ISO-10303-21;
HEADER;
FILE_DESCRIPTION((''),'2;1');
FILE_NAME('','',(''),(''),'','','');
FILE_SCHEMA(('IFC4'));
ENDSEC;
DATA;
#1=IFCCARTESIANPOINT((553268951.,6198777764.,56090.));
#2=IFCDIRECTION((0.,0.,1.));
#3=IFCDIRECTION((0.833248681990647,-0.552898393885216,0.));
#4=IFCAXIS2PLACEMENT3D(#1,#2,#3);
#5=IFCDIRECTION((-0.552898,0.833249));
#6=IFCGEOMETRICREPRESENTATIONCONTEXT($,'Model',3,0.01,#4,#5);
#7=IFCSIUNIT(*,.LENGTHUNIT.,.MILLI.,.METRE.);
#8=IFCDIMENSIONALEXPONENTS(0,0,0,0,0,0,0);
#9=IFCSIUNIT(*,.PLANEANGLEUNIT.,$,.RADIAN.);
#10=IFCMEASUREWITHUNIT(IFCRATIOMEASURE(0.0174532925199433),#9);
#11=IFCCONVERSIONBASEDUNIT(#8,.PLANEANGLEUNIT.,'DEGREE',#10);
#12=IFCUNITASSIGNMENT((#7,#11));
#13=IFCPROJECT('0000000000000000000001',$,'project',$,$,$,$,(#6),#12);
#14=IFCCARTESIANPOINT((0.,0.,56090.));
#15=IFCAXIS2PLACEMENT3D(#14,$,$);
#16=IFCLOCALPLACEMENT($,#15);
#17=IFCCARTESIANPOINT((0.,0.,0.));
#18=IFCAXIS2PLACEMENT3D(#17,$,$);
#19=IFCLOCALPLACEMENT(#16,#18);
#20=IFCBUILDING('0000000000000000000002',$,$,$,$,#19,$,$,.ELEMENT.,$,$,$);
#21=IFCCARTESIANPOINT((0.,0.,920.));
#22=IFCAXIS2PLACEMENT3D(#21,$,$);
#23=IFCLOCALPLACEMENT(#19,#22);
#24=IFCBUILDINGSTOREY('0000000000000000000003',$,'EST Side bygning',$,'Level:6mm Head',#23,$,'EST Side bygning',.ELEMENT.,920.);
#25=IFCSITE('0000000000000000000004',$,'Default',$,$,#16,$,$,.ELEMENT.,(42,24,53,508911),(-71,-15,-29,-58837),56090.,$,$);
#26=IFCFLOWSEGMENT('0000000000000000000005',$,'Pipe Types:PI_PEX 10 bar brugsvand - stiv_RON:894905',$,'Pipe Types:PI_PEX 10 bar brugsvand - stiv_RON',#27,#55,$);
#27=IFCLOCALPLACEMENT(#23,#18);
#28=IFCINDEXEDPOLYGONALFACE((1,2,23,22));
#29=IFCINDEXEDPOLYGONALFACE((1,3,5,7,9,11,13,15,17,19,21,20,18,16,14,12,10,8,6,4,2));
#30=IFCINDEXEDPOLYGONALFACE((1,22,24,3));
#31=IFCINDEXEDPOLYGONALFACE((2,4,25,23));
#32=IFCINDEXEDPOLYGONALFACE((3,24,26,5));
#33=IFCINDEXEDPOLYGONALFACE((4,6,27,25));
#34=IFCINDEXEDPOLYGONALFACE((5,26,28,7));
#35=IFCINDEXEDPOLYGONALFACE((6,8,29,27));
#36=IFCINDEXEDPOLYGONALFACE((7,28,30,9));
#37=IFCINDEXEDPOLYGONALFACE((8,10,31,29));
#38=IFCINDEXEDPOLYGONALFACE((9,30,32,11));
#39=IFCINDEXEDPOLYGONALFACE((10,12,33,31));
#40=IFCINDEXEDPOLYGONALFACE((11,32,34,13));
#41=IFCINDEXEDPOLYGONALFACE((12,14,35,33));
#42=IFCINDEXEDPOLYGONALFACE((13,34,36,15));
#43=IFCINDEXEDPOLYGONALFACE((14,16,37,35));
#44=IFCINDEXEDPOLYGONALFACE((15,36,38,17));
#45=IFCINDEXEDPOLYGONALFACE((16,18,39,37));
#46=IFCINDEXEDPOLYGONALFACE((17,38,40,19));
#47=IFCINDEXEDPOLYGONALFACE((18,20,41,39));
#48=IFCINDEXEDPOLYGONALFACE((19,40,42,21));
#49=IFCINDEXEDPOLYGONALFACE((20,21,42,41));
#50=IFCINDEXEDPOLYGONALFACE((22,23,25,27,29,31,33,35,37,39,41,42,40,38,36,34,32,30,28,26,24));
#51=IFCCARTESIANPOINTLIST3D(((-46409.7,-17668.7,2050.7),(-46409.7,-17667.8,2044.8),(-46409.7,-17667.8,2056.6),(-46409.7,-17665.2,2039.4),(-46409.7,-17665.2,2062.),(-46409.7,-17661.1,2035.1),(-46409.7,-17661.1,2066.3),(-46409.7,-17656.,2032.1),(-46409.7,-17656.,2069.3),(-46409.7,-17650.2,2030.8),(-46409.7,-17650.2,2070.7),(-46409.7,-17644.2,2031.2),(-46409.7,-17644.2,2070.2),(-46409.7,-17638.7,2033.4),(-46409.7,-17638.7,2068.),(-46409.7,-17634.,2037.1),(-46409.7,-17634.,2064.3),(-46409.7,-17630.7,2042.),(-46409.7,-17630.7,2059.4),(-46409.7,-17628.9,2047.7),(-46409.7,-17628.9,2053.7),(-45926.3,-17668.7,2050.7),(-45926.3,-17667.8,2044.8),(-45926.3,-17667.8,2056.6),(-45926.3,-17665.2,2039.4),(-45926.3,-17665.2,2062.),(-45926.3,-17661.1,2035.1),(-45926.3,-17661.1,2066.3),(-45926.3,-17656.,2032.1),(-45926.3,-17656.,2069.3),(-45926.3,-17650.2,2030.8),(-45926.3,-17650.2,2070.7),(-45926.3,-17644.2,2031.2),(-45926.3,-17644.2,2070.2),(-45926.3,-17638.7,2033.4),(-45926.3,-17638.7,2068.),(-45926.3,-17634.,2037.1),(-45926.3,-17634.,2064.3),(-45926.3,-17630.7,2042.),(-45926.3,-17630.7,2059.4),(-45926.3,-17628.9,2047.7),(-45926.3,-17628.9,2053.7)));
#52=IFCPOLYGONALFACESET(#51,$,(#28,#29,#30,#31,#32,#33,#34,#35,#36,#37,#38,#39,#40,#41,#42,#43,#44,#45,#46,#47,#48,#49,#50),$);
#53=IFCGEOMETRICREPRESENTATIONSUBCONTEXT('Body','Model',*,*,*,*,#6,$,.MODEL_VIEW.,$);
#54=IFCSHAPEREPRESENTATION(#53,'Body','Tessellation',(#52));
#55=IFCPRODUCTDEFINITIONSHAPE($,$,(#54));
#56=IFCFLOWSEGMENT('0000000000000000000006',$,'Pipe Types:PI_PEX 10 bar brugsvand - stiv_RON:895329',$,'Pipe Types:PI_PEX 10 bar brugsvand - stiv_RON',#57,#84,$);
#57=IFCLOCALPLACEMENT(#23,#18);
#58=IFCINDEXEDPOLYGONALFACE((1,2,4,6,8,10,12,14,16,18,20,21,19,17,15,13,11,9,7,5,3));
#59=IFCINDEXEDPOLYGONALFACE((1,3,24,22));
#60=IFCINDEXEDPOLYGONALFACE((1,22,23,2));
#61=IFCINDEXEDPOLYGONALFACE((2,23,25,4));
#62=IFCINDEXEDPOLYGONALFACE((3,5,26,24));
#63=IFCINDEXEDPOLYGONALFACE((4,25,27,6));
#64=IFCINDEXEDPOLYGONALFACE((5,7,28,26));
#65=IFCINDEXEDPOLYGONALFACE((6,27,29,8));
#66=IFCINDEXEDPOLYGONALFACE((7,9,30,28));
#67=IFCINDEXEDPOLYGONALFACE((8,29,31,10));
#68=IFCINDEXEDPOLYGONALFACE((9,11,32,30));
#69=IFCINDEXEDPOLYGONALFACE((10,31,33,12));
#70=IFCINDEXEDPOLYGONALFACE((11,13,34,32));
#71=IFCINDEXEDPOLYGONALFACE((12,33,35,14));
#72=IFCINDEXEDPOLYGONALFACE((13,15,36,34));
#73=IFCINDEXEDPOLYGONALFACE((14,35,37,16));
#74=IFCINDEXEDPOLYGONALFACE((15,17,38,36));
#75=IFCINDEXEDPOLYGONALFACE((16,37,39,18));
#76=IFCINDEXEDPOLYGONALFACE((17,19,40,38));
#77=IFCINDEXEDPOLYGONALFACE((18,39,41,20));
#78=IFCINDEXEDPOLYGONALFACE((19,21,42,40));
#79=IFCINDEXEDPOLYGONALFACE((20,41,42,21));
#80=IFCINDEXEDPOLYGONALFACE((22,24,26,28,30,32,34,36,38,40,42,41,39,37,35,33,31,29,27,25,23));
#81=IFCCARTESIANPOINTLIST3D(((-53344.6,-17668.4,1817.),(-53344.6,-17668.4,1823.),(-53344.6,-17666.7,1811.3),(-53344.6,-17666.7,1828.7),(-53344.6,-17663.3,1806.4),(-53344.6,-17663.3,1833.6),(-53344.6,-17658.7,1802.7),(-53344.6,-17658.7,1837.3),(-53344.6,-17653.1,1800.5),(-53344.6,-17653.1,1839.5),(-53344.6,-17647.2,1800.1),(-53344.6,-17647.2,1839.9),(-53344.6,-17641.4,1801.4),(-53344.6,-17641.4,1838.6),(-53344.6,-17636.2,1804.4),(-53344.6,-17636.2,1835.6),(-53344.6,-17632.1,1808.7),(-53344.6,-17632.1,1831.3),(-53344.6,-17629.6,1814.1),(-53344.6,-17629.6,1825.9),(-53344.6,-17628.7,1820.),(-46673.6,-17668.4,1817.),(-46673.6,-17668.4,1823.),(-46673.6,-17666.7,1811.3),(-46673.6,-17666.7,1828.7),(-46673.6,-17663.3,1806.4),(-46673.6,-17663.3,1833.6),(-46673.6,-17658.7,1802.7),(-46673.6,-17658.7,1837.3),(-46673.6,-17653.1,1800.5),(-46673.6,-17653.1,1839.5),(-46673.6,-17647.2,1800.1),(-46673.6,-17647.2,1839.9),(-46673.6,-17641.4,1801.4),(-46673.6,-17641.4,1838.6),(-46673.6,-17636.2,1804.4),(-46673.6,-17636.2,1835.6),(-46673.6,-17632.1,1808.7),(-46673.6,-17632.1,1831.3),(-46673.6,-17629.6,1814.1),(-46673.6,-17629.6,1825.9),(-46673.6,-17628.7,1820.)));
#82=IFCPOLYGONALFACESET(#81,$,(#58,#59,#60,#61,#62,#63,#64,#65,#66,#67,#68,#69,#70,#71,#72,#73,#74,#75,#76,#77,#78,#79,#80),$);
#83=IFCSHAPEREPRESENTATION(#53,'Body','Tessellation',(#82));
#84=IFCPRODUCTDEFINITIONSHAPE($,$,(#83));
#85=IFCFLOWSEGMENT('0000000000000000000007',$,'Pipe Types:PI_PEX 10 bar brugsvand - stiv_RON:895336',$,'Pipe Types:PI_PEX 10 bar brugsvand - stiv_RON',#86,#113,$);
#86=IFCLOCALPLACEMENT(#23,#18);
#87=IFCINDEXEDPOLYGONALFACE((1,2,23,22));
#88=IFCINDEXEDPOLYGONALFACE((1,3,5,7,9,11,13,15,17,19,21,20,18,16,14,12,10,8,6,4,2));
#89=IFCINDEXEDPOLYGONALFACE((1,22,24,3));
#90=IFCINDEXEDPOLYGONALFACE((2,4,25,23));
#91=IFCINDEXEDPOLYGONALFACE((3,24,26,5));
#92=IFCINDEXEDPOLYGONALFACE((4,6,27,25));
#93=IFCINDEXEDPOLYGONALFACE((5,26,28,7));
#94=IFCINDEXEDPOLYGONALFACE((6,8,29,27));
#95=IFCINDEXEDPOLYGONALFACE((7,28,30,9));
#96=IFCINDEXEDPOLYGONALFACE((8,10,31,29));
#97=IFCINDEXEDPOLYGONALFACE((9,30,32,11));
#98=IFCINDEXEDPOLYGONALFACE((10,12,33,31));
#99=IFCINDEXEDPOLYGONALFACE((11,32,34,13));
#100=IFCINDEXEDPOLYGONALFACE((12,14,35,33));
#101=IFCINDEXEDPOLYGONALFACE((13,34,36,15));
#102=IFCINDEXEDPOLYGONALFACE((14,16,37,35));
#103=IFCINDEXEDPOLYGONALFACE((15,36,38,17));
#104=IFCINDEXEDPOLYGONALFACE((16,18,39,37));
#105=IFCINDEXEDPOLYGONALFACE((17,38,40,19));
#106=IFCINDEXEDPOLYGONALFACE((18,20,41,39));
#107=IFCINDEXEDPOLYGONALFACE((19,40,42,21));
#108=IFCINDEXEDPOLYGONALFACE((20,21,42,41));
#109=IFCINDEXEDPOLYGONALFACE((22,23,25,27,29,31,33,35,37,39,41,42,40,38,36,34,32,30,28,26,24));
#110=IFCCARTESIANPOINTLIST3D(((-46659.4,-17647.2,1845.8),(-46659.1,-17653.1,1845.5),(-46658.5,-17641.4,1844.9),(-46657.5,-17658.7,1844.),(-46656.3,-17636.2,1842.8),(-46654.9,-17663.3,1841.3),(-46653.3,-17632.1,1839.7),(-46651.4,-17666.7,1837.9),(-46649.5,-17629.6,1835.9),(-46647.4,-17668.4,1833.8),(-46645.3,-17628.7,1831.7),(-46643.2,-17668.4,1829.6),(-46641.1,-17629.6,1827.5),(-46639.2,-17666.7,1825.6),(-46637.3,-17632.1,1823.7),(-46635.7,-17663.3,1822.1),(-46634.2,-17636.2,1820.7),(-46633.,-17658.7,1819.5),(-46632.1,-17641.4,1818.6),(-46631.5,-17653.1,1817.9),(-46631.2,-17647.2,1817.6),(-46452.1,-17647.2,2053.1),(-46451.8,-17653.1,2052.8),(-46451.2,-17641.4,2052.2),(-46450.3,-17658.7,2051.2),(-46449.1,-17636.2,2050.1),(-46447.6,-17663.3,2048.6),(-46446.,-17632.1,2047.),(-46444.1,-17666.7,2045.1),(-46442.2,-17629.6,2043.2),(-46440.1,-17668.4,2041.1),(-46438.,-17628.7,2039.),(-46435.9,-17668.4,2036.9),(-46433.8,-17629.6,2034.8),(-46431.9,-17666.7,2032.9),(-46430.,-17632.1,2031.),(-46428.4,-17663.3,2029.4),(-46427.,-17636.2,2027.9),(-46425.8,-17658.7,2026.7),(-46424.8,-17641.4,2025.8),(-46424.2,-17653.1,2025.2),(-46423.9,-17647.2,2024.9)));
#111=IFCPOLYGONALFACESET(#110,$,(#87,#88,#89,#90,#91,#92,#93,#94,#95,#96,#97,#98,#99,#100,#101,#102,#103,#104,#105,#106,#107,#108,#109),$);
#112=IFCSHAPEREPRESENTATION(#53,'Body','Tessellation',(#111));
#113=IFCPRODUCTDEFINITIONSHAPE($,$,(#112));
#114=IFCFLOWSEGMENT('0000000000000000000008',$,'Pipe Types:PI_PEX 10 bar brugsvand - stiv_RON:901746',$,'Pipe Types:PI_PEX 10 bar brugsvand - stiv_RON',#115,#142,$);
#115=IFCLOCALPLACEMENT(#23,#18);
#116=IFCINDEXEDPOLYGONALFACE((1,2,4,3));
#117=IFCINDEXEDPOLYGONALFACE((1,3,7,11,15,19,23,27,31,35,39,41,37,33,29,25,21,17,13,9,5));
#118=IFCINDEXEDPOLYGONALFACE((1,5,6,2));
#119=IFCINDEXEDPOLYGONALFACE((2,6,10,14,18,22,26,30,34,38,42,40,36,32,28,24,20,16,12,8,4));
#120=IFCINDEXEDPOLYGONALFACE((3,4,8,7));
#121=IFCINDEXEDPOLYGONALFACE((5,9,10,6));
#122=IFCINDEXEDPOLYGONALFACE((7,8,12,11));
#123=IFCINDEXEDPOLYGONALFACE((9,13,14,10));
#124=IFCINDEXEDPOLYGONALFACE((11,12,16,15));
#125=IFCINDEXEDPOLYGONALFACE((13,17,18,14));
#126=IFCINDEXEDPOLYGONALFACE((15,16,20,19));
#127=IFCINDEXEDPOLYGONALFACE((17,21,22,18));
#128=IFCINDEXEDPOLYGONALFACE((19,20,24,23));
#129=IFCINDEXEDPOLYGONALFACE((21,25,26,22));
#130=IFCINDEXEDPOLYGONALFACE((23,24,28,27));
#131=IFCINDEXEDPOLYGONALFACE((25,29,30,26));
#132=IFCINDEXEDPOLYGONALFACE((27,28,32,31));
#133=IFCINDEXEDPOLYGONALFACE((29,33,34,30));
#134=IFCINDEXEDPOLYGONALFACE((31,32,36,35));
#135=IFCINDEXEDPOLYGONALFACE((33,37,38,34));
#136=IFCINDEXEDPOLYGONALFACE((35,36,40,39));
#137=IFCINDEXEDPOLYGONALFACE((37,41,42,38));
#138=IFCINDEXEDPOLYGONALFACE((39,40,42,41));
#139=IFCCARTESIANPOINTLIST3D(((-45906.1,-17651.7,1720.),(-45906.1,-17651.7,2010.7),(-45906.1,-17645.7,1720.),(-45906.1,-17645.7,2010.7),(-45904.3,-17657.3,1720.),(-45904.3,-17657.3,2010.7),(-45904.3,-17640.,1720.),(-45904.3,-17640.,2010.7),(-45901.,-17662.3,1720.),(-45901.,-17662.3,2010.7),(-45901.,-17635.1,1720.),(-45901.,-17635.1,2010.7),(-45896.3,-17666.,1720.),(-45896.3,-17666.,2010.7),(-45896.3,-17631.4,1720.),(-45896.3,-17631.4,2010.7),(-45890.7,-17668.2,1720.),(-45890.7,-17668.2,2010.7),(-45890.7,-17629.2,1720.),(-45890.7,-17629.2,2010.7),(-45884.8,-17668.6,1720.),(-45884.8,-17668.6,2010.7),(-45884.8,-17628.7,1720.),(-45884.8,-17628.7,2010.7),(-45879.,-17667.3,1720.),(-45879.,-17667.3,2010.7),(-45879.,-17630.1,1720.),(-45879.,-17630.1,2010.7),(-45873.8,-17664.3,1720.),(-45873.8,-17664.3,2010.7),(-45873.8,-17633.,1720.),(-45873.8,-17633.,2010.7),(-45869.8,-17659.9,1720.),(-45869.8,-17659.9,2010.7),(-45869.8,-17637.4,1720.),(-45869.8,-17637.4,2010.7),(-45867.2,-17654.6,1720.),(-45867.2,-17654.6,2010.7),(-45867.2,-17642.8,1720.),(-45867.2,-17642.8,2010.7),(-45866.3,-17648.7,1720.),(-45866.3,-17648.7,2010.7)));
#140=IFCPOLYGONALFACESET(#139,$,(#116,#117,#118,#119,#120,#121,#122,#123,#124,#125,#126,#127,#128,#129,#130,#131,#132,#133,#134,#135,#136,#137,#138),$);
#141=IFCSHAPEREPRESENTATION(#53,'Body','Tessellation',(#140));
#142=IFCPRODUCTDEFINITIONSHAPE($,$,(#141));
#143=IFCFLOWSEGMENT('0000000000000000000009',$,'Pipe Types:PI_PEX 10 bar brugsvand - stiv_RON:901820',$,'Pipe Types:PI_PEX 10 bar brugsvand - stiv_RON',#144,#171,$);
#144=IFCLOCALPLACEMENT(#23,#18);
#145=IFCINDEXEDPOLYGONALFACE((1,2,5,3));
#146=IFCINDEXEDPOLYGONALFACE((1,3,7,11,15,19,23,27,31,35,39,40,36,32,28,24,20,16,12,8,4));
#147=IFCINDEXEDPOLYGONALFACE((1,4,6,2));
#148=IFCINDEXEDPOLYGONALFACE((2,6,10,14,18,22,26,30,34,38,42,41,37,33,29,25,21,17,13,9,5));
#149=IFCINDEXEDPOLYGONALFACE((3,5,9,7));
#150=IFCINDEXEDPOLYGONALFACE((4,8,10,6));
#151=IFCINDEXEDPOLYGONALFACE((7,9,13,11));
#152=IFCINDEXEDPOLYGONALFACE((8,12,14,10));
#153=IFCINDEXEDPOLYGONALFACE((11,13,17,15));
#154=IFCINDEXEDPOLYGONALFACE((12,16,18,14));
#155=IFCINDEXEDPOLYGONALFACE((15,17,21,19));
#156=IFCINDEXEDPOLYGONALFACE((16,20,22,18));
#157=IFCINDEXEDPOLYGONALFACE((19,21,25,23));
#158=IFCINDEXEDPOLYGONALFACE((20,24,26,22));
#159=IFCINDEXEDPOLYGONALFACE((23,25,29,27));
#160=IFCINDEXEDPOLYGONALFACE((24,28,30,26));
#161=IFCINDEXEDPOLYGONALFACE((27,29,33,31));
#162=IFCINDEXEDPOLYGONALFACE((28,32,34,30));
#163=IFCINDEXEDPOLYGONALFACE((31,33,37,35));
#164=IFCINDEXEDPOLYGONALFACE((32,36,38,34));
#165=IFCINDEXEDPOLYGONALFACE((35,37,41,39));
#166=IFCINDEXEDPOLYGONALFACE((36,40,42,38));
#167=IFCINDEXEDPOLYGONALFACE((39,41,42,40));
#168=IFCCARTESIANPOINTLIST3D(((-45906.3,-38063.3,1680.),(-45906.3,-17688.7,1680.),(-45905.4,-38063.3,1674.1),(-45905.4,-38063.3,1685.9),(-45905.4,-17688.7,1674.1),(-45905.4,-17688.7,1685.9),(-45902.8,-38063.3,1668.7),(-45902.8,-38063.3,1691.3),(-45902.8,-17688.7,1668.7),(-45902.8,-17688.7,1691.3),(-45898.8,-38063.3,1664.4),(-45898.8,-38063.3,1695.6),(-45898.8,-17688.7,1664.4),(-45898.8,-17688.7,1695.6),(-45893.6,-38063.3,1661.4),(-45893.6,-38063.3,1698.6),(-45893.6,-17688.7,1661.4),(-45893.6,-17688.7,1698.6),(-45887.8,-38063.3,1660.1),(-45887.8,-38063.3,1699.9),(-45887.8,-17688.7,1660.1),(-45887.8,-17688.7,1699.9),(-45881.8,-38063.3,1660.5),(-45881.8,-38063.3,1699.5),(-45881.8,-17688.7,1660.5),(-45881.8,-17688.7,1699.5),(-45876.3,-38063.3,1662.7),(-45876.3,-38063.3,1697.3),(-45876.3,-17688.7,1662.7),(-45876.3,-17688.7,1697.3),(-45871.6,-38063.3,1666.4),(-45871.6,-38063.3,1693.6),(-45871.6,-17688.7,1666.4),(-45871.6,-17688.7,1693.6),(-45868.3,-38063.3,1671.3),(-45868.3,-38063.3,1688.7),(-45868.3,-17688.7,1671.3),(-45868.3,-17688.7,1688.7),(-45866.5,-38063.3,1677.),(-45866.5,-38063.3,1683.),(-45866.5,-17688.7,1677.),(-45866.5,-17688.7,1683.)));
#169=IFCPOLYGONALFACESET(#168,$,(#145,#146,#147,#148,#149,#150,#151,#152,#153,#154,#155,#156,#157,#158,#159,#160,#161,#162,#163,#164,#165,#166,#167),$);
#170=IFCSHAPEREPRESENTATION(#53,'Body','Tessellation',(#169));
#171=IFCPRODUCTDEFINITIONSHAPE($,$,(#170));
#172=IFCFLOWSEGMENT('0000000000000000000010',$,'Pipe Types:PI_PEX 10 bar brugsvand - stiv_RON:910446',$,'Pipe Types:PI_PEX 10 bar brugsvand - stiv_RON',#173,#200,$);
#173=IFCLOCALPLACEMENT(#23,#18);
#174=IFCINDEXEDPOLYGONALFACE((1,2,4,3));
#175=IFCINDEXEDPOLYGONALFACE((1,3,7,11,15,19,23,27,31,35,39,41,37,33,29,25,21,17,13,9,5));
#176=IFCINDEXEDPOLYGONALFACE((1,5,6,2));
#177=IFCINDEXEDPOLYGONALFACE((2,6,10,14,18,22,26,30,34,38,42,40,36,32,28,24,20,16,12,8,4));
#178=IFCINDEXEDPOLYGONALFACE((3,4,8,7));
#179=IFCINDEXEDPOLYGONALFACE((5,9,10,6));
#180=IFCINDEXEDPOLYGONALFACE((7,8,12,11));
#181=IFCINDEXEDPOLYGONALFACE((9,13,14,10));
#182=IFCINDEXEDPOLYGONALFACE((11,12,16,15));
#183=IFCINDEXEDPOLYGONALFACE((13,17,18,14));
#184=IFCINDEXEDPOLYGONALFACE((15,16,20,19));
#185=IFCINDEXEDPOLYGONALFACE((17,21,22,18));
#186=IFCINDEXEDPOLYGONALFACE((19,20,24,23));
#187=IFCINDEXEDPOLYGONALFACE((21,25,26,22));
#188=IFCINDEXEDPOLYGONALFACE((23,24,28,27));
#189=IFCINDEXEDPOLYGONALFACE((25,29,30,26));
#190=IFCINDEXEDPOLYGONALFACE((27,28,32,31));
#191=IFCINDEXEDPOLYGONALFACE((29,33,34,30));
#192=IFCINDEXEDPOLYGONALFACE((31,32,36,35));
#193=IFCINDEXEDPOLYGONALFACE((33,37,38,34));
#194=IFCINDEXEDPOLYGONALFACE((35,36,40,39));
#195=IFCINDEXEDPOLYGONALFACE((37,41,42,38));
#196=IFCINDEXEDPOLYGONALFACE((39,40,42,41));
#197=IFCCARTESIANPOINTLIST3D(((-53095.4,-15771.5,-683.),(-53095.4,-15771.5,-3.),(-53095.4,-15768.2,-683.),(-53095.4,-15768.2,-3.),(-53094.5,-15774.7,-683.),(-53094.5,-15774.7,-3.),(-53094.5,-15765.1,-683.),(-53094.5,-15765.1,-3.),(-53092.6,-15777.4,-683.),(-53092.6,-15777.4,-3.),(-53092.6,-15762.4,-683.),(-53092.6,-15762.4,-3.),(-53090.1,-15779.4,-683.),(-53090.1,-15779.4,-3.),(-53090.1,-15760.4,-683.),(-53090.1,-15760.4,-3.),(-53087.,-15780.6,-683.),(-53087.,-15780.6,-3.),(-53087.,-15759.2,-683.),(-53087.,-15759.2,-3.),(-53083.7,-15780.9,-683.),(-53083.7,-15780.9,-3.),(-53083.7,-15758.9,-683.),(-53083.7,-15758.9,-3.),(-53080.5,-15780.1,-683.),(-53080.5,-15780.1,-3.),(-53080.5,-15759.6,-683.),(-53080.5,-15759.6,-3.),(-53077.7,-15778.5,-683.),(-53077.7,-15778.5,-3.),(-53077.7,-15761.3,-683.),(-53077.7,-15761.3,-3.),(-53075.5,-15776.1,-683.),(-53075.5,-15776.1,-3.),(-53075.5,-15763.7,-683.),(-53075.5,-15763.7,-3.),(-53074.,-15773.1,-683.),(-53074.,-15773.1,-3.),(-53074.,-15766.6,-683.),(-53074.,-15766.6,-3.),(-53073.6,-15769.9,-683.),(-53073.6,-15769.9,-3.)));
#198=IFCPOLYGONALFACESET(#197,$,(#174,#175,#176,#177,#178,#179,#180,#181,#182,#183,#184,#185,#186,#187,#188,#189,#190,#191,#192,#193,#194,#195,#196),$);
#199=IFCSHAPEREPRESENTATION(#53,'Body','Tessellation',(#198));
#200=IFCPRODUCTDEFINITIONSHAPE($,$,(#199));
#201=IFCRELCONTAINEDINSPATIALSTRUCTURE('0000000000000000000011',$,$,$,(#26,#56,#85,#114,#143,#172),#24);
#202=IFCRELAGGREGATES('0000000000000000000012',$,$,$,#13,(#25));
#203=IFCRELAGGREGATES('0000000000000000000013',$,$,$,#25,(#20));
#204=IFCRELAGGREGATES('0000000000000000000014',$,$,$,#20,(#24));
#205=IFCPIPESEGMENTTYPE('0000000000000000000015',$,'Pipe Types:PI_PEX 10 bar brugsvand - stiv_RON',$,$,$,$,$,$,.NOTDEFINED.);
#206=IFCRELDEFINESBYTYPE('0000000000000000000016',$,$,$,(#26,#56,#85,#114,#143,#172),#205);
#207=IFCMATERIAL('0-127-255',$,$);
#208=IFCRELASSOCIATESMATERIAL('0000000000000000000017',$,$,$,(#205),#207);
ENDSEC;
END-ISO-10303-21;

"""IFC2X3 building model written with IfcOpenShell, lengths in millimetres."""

from ifc_helpers import new_model, entity, si_unit, converted_unit, direction, frame, frame_2d, origin, origin_2d_with_axis, place, context, subcontext, project, spatial, circle, extrude, material, type_object, element, save


model = new_model("IFC2X3")

# Units and contexts
model_context = context("Model", 3, precision=0.01, world=frame((553268951.0, 6198777764.0, 56090.0), z_axis=(0.0, 0.0, 1.0), x_axis=(0.833248681990647, -0.552898393885216, 0.0)), true_north=direction((-0.552898, 0.833249)))
body_context = subcontext(model_context, "Body", "Model", "MODEL_VIEW")
ifc_project = project(units=[si_unit("LENGTHUNIT", "METRE", prefix="MILLI"), converted_unit("PLANEANGLEUNIT", "DEGREE", entity("IfcRatioMeasure", 0.0174532925199433), si_unit("PLANEANGLEUNIT", "RADIAN"), dimensions=[0, 0, 0, 0, 0, 0, 0])], contexts=[model_context])

# Site, building, storey
site_placement = place(None, frame((0.0, 0.0, 56090.0)))
site = spatial("IfcSite", under=ifc_project, at=site_placement, Name="Default", CompositionType="ELEMENT", RefLatitude=(42, 24, 53, 508911), RefLongitude=(-71, -15, -29, -58837), RefElevation=56090.0)
building_placement = place(site_placement, origin())
building = spatial("IfcBuilding", under=site, at=building_placement, CompositionType="ELEMENT")
storey_placement = place(building_placement, frame((0.0, 0.0, 920.0)))
storey = spatial("IfcBuildingStorey", under=building, at=storey_placement, Name="EST Side bygning", ObjectType="Level:6mm Head", LongName="EST Side bygning", CompositionType="ELEMENT", Elevation=920.0)

# Flow segments
ifc_material_1 = material(Name="0-127-255")
pipe_segment_type_1 = type_object("IfcPipeSegmentType", Name="Pipe Types:PI_PEX 10 bar brugsvand - stiv_RON", PredefinedType="NOTDEFINED", material=ifc_material_1)
flow_segment_1_placement = place(storey_placement, origin())
element("IfcFlowSegment", 1, at=flow_segment_1_placement, inside=storey, type_object=pipe_segment_type_1, Name="Pipe Types:PI_PEX 10 bar brugsvand - stiv_RON:894905", ObjectType="Pipe Types:PI_PEX 10 bar brugsvand - stiv_RON", context=body_context, shape_type="SweptSolid", body=[
    extrude(circle(Radius=20.0, at=origin_2d_with_axis()), frame((-46409.7, -17648.7, 2050.7), z_axis=(1.0, 0.0, 0.0), x_axis=(0.0, -1.0, 0.0)), (0.0, 0.0, 1.0), 483.4),
])
flow_segment_2_placement = place(storey_placement, origin())
element("IfcFlowSegment", 2, at=flow_segment_2_placement, inside=storey, type_object=pipe_segment_type_1, Name="Pipe Types:PI_PEX 10 bar brugsvand - stiv_RON:895329", ObjectType="Pipe Types:PI_PEX 10 bar brugsvand - stiv_RON", context=body_context, shape_type="SweptSolid", body=[
    extrude(circle(Radius=20.0, at=frame_2d((0.0, 0.0), x_axis=(1.0, 0.0))), frame((-53344.6, -17648.7, 1820.0), z_axis=(1.0, 0.0, 0.0), x_axis=(0.0, 1.0, 0.0)), (0.0, 0.0, 1.0), 6671.0),
])
flow_segment_3_placement = place(storey_placement, origin())
element("IfcFlowSegment", 3, at=flow_segment_3_placement, inside=storey, type_object=pipe_segment_type_1, Name="Pipe Types:PI_PEX 10 bar brugsvand - stiv_RON:895336", ObjectType="Pipe Types:PI_PEX 10 bar brugsvand - stiv_RON", context=body_context, shape_type="SweptSolid", body=[
    extrude(circle(Radius=20.0, at=origin_2d_with_axis()), frame((-46645.3, -17648.7, 1831.7), z_axis=(0.707107, 0.0, 0.707107), x_axis=(0.0, 1.0, 0.0)), (0.0, 0.0, 1.0), 293.1),
])
flow_segment_4_placement = place(storey_placement, origin())
element("IfcFlowSegment", 4, at=flow_segment_4_placement, inside=storey, type_object=pipe_segment_type_1, Name="Pipe Types:PI_PEX 10 bar brugsvand - stiv_RON:901746", ObjectType="Pipe Types:PI_PEX 10 bar brugsvand - stiv_RON", context=body_context, shape_type="SweptSolid", body=[
    extrude(circle(Radius=20.0, at=frame_2d((0.0, 0.0), x_axis=(1.0, 0.0))), frame((-45886.3, -17648.7, 1720.0)), (0.0, 0.0, 1.0), 290.7),
])
flow_segment_5_placement = place(storey_placement, origin())
element("IfcFlowSegment", 5, at=flow_segment_5_placement, inside=storey, type_object=pipe_segment_type_1, Name="Pipe Types:PI_PEX 10 bar brugsvand - stiv_RON:901820", ObjectType="Pipe Types:PI_PEX 10 bar brugsvand - stiv_RON", context=body_context, shape_type="SweptSolid", body=[
    extrude(circle(Radius=20.0, at=origin_2d_with_axis()), frame((-45886.3, -38063.3, 1680.0), z_axis=(0.0, 1.0, 0.0), x_axis=(-1.0, 0.0, 0.0)), (0.0, 0.0, 1.0), 20374.6),
])
flow_segment_6_placement = place(storey_placement, origin())
element("IfcFlowSegment", 6, at=flow_segment_6_placement, inside=storey, type_object=pipe_segment_type_1, Name="Pipe Types:PI_PEX 10 bar brugsvand - stiv_RON:910446", ObjectType="Pipe Types:PI_PEX 10 bar brugsvand - stiv_RON", context=body_context, shape_type="SweptSolid", body=[
    extrude(circle(Radius=11.0, at=origin_2d_with_axis()), frame((-53084.6, -15769.9, -683.0)), (0.0, 0.0, 1.0), 680.0),
])

save(model, "model.ifc")
